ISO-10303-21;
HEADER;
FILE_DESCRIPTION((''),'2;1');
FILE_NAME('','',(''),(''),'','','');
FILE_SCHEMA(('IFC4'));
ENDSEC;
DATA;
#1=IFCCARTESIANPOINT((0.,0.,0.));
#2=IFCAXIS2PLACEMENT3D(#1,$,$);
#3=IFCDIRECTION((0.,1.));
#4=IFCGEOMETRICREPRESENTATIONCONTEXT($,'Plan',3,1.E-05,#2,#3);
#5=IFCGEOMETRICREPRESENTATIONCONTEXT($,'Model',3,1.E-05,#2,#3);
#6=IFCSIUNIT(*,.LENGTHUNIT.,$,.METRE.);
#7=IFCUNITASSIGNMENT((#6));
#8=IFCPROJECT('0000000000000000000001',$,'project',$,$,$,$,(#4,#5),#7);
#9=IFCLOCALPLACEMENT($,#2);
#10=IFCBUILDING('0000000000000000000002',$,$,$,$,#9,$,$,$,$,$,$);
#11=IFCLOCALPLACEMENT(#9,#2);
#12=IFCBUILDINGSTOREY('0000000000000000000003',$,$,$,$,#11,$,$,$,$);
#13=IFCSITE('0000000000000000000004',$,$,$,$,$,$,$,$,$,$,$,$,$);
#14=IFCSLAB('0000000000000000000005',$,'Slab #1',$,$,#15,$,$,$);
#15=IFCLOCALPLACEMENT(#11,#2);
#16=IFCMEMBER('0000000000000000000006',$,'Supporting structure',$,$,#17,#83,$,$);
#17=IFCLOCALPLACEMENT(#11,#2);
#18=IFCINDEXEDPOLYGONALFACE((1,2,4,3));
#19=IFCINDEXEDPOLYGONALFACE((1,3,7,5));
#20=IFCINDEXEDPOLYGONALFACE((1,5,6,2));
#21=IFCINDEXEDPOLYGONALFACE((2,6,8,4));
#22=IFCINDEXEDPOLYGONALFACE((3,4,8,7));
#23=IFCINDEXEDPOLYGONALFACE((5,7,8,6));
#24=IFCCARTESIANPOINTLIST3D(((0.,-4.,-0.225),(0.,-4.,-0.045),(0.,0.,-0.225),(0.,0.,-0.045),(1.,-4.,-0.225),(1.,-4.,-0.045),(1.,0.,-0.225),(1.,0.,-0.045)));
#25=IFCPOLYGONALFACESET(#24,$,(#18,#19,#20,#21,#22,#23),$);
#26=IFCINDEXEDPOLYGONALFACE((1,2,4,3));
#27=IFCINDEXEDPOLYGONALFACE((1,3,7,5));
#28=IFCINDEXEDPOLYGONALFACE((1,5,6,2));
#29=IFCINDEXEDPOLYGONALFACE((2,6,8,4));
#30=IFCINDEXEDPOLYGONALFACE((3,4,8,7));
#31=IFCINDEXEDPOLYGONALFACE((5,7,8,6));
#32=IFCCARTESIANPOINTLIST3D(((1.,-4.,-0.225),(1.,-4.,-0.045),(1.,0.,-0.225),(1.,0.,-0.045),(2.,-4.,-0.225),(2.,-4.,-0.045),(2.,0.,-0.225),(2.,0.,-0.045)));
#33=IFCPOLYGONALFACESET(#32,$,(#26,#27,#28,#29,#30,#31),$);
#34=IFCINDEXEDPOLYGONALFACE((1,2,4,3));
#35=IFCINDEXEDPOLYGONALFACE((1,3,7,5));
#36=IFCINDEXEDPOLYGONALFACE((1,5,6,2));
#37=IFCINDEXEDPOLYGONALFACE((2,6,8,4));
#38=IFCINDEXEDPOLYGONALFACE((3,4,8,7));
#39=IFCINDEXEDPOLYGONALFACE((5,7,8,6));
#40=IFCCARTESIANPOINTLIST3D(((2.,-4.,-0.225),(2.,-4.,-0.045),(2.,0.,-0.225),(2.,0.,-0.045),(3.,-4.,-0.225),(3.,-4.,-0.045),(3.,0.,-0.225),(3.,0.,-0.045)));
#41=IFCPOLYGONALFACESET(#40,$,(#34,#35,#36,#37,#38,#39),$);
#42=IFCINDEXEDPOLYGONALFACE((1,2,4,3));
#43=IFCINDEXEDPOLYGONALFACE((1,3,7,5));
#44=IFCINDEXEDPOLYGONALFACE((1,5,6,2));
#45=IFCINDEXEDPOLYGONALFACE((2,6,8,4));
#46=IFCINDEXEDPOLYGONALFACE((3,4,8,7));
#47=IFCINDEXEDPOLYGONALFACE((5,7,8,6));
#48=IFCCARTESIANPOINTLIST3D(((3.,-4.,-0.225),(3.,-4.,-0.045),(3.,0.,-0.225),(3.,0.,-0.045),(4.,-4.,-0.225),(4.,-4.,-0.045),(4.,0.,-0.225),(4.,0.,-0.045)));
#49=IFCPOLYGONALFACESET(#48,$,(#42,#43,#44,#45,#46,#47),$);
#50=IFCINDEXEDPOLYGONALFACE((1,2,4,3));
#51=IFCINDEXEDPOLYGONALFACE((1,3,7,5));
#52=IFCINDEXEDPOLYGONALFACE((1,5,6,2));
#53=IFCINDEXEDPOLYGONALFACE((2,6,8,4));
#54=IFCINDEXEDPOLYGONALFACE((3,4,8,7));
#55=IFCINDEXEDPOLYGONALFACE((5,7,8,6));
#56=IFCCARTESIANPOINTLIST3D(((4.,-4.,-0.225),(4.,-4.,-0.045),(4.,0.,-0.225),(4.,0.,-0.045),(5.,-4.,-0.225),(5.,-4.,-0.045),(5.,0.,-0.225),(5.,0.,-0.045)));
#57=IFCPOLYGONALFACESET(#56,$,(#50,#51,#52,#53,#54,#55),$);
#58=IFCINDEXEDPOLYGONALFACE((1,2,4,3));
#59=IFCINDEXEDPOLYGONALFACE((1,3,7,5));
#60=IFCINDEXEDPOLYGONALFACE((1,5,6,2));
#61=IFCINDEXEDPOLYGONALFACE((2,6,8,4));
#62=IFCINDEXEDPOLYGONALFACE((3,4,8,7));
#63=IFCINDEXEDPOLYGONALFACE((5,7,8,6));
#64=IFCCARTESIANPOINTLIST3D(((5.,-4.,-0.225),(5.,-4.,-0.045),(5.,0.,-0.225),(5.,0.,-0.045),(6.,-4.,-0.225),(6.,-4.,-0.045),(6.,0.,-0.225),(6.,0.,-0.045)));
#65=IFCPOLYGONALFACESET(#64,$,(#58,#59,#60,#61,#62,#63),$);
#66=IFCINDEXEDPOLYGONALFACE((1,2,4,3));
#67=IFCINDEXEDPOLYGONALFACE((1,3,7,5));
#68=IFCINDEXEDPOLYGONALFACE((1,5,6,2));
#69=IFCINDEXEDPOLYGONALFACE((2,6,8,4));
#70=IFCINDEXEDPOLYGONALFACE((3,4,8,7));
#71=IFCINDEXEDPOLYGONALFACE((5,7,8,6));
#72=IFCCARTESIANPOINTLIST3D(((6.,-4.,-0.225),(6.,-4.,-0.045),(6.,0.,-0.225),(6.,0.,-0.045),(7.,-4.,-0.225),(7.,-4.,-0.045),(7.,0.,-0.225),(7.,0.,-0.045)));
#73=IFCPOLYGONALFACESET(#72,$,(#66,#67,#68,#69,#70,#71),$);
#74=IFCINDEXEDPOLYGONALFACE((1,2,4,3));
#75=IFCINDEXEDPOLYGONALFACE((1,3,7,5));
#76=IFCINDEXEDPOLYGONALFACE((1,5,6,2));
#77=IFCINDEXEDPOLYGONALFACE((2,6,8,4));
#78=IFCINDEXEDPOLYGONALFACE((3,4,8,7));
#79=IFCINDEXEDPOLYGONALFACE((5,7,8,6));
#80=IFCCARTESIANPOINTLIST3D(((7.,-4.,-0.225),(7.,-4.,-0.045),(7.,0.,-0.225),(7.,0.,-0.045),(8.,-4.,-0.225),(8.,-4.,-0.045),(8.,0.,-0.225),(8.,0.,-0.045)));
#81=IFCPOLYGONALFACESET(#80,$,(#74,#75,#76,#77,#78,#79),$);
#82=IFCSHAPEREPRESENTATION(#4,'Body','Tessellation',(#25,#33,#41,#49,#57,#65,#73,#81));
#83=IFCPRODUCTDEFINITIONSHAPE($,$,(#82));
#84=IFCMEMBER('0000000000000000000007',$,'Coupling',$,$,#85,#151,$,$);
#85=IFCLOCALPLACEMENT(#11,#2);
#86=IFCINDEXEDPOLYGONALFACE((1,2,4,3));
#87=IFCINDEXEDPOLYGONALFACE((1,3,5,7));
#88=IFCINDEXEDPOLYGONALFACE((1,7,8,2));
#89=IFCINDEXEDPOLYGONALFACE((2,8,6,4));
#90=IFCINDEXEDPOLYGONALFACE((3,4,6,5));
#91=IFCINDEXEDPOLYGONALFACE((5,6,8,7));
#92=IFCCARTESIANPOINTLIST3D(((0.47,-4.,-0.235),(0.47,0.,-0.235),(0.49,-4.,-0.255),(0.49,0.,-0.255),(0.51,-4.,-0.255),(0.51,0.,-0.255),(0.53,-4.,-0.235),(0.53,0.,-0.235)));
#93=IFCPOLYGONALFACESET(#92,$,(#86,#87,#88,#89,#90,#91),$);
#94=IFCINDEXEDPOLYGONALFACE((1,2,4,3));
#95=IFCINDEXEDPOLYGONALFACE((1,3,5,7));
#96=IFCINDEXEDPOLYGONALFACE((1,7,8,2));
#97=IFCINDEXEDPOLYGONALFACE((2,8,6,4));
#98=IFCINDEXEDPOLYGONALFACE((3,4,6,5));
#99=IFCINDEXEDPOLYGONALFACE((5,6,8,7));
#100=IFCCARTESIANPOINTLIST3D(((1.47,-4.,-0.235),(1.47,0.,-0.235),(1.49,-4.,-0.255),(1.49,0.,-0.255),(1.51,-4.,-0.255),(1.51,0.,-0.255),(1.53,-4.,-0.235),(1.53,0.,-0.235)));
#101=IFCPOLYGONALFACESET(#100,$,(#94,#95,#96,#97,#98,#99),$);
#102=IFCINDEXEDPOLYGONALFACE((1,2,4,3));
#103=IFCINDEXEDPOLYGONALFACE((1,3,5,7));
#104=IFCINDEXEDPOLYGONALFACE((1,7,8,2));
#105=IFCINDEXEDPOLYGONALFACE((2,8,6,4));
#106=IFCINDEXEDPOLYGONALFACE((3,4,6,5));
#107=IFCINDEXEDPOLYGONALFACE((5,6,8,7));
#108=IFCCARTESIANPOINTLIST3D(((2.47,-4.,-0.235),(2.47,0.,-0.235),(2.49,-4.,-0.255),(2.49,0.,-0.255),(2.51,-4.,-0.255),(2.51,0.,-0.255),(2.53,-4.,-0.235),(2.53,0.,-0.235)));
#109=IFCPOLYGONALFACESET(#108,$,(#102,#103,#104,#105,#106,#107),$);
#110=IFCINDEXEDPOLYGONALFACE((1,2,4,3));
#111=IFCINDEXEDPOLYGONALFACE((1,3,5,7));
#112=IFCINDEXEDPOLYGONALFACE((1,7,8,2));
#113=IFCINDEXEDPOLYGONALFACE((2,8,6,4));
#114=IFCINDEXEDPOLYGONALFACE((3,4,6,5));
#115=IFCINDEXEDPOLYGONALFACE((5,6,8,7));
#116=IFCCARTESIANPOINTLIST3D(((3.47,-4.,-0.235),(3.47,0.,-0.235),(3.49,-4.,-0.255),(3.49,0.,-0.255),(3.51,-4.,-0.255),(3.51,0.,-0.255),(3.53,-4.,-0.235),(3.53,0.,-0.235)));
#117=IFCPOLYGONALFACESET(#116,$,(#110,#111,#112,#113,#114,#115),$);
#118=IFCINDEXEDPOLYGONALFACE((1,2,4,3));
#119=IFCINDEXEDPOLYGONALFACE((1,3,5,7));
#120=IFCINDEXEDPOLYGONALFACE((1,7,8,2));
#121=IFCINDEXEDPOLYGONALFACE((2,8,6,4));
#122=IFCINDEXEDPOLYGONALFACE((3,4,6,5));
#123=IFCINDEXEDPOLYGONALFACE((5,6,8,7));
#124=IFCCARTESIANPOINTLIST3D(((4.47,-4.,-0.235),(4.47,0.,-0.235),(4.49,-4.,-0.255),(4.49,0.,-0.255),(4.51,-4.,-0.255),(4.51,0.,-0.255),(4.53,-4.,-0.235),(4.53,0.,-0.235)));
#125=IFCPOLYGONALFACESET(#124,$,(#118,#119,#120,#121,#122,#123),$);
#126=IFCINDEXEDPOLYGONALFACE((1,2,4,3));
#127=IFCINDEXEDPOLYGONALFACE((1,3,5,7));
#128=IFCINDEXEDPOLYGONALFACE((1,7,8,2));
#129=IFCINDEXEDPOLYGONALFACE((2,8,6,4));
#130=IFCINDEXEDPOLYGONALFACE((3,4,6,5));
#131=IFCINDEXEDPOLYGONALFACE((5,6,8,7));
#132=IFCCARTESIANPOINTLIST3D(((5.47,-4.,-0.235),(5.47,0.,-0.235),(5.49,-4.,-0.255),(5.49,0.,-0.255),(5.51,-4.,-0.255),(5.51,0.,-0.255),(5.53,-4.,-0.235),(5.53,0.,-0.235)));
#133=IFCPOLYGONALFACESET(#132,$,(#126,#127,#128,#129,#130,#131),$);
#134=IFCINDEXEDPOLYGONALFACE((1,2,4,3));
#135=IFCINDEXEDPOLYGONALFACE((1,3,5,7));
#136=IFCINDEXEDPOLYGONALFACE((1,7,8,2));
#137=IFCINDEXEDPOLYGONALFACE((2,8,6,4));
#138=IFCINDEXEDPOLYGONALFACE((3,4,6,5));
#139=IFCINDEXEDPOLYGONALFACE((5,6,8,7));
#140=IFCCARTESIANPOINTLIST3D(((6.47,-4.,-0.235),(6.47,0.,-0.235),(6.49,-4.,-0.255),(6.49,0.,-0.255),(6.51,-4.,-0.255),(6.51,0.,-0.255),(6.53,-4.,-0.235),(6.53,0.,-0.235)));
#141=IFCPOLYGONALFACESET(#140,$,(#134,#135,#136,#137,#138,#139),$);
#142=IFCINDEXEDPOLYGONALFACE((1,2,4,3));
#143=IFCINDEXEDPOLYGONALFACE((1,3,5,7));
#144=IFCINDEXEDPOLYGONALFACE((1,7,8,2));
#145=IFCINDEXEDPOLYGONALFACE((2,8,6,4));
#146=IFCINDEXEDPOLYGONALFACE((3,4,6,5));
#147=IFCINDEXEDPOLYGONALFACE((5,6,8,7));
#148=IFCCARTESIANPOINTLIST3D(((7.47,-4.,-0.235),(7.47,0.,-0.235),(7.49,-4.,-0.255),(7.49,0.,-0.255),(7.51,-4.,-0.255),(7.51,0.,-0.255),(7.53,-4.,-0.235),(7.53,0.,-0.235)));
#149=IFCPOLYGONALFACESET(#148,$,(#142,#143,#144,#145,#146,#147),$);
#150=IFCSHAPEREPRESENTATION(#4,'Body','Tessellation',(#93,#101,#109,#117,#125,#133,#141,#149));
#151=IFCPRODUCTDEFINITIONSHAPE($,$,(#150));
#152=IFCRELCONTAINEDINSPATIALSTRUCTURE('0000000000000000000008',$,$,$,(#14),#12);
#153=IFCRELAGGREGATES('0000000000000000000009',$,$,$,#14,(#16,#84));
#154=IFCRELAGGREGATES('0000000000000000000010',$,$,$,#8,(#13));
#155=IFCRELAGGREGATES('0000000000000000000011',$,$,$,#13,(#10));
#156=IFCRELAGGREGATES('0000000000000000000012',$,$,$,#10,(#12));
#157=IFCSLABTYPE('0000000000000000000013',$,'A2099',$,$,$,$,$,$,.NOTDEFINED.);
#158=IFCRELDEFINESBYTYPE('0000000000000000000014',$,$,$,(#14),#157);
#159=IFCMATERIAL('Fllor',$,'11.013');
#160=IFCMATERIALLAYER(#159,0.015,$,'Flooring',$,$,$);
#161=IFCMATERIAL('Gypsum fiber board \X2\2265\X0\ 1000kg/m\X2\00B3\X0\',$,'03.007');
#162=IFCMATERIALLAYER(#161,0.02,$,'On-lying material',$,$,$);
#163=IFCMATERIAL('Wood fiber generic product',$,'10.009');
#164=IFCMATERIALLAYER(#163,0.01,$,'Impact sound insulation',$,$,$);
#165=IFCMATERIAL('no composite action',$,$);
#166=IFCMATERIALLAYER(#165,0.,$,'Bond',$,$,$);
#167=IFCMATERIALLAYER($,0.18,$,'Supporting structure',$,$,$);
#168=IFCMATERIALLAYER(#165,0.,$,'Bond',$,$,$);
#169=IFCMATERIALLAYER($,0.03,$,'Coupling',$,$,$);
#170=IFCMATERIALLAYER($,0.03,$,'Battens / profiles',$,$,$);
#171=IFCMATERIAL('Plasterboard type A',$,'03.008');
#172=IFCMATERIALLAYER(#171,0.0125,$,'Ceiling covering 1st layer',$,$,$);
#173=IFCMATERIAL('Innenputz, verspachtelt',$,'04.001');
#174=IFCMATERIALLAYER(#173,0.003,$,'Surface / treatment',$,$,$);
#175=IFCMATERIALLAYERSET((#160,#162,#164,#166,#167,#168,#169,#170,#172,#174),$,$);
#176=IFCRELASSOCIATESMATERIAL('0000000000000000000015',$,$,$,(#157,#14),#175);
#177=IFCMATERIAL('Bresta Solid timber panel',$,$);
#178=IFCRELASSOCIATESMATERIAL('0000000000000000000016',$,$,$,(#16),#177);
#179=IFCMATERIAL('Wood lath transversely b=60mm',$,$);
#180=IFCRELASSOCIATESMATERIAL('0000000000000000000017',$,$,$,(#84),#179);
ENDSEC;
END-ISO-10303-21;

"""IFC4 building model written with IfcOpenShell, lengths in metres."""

from ifc_helpers import new_model, si_unit, direction, frame, frame_2d, origin, place, context, project, spatial, polyline, rectangle, outline, extrude, material, layer, layer_set, type_object, element, aggregate, save


model = new_model("IFC4")

# Units and contexts
plan_context = context("Plan", 3, precision=1e-05, world=origin(), true_north=direction((0.0, 1.0)))
model_context = context("Model", 3, precision=1e-05, world=origin(), true_north=direction((0.0, 1.0)))
ifc_project = project(units=[si_unit("LENGTHUNIT", "METRE")], contexts=[plan_context, model_context])

# Site, building, storey
site = spatial("IfcSite", under=ifc_project)
building_placement = place(None, origin())
building = spatial("IfcBuilding", under=site, at=building_placement)
storey_placement = place(building_placement, origin())
storey = spatial("IfcBuildingStorey", under=building, at=storey_placement)

# Slab, members
ifc_material_1 = material(Name="Fllor", Category="11.013")
ifc_layer_1 = layer(ifc_material_1, 0.015, Name="Flooring")
ifc_material_2 = material(Name="Gypsum fiber board ≥ 1000kg/m³", Category="03.007")
ifc_layer_2 = layer(ifc_material_2, 0.02, Name="On-lying material")
ifc_material_3 = material(Name="Wood fiber generic product", Category="10.009")
ifc_layer_3 = layer(ifc_material_3, 0.01, Name="Impact sound insulation")
ifc_material_4 = material(Name="no composite action")
ifc_layer_4 = layer(ifc_material_4, 0.0, Name="Bond")
ifc_layer_5 = layer(None, 0.18, Name="Supporting structure")
ifc_layer_6 = layer(ifc_material_4, 0.0, Name="Bond")
ifc_layer_7 = layer(None, 0.03, Name="Coupling")
ifc_layer_8 = layer(None, 0.03, Name="Battens / profiles")
ifc_material_5 = material(Name="Plasterboard type A", Category="03.008")
ifc_layer_9 = layer(ifc_material_5, 0.0125, Name="Ceiling covering 1st layer")
ifc_material_6 = material(Name="Innenputz, verspachtelt", Category="04.001")
ifc_layer_10 = layer(ifc_material_6, 0.003, Name="Surface / treatment")
ifc_layer_set = layer_set([ifc_layer_1, ifc_layer_2, ifc_layer_3, ifc_layer_4, ifc_layer_5, ifc_layer_6, ifc_layer_7, ifc_layer_8, ifc_layer_9, ifc_layer_10])
slab_type = type_object("IfcSlabType", Name="A2099", PredefinedType="NOTDEFINED", material=ifc_layer_set)
slab_placement = place(None, frame((0.0, 0.0, 0.0), z_axis=(0.0, 0.0, -1.0), x_axis=(1.0, 0.0, 0.0)))
slab = element("IfcSlab", 1, at=slab_placement, inside=storey, type_object=slab_type, material=ifc_layer_set, Name="Slab #1")
ifc_material_7 = material(Name="Bresta Solid timber panel")
member_1_placement = place(slab_placement, origin())
member_1 = element("IfcMember", 2, at=member_1_placement, material=ifc_material_7, Name="Supporting structure", context=plan_context, shape_type="SweptSolid", body=[
    extrude(rectangle(XDim=1.0, YDim=0.18, at=frame_2d((0.5, 0.09), x_axis=(1.0, 0.0))), frame((0.0, 4.0, 0.045), z_axis=(0.0, -1.0, 0.0), x_axis=(1.0, 0.0, 0.0)), (0.0, 0.0, 1.0), 4.0),
    extrude(rectangle(XDim=1.0, YDim=0.18, at=frame_2d((0.5, 0.09), x_axis=(1.0, 0.0))), frame((1.0, 4.0, 0.045), z_axis=(0.0, -1.0, 0.0), x_axis=(1.0, 0.0, 0.0)), (0.0, 0.0, 1.0), 4.0),
    extrude(rectangle(XDim=1.0, YDim=0.18, at=frame_2d((0.5, 0.09), x_axis=(1.0, 0.0))), frame((2.0, 4.0, 0.045), z_axis=(0.0, -1.0, 0.0), x_axis=(1.0, 0.0, 0.0)), (0.0, 0.0, 1.0), 4.0),
    extrude(rectangle(XDim=1.0, YDim=0.18, at=frame_2d((0.5, 0.09), x_axis=(1.0, 0.0))), frame((3.0, 4.0, 0.045), z_axis=(0.0, -1.0, 0.0), x_axis=(1.0, 0.0, 0.0)), (0.0, 0.0, 1.0), 4.0),
    extrude(rectangle(XDim=1.0, YDim=0.18, at=frame_2d((0.5, 0.09), x_axis=(1.0, 0.0))), frame((4.0, 4.0, 0.045), z_axis=(0.0, -1.0, 0.0), x_axis=(1.0, 0.0, 0.0)), (0.0, 0.0, 1.0), 4.0),
    extrude(rectangle(XDim=1.0, YDim=0.18, at=frame_2d((0.5, 0.09), x_axis=(1.0, 0.0))), frame((5.0, 4.0, 0.045), z_axis=(0.0, -1.0, 0.0), x_axis=(1.0, 0.0, 0.0)), (0.0, 0.0, 1.0), 4.0),
    extrude(rectangle(XDim=1.0, YDim=0.18, at=frame_2d((0.5, 0.09), x_axis=(1.0, 0.0))), frame((6.0, 4.0, 0.045), z_axis=(0.0, -1.0, 0.0), x_axis=(1.0, 0.0, 0.0)), (0.0, 0.0, 1.0), 4.0),
    extrude(rectangle(XDim=1.0, YDim=0.18, at=frame_2d((0.5, 0.09), x_axis=(1.0, 0.0))), frame((7.0, 4.0, 0.045), z_axis=(0.0, -1.0, 0.0), x_axis=(1.0, 0.0, 0.0)), (0.0, 0.0, 1.0), 4.0),
])
ifc_material_8 = material(Name="Wood lath transversely b=60mm")
member_2_placement = place(slab_placement, origin())
member_2 = element("IfcMember", 3, at=member_2_placement, material=ifc_material_8, Name="Coupling", context=plan_context, shape_type="SweptSolid", body=[
    extrude(outline(polyline([(0.0, 0.0), (0.06, 0.0), (0.04, 0.02), (0.02, 0.02), (0.0, 0.0)])), frame((0.47, 4.0, 0.235), z_axis=(0.0, -1.0, 0.0), x_axis=(1.0, 0.0, 0.0)), (0.0, 0.0, 1.0), 4.0),
    extrude(outline(polyline([(0.0, 0.0), (0.06, 0.0), (0.04, 0.02), (0.02, 0.02), (0.0, 0.0)])), frame((1.47, 4.0, 0.235), z_axis=(0.0, -1.0, 0.0), x_axis=(1.0, 0.0, 0.0)), (0.0, 0.0, 1.0), 4.0),
    extrude(outline(polyline([(0.0, 0.0), (0.06, 0.0), (0.04, 0.02), (0.02, 0.02), (0.0, 0.0)])), frame((2.47, 4.0, 0.235), z_axis=(0.0, -1.0, 0.0), x_axis=(1.0, 0.0, 0.0)), (0.0, 0.0, 1.0), 4.0),
    extrude(outline(polyline([(0.0, 0.0), (0.06, 0.0), (0.04, 0.02), (0.02, 0.02), (0.0, 0.0)])), frame((3.47, 4.0, 0.235), z_axis=(0.0, -1.0, 0.0), x_axis=(1.0, 0.0, 0.0)), (0.0, 0.0, 1.0), 4.0),
    extrude(outline(polyline([(0.0, 0.0), (0.06, 0.0), (0.04, 0.02), (0.02, 0.02), (0.0, 0.0)])), frame((4.47, 4.0, 0.235), z_axis=(0.0, -1.0, 0.0), x_axis=(1.0, 0.0, 0.0)), (0.0, 0.0, 1.0), 4.0),
    extrude(outline(polyline([(0.0, 0.0), (0.06, 0.0), (0.04, 0.02), (0.02, 0.02), (0.0, 0.0)])), frame((5.47, 4.0, 0.235), z_axis=(0.0, -1.0, 0.0), x_axis=(1.0, 0.0, 0.0)), (0.0, 0.0, 1.0), 4.0),
    extrude(outline(polyline([(0.0, 0.0), (0.06, 0.0), (0.04, 0.02), (0.02, 0.02), (0.0, 0.0)])), frame((6.47, 4.0, 0.235), z_axis=(0.0, -1.0, 0.0), x_axis=(1.0, 0.0, 0.0)), (0.0, 0.0, 1.0), 4.0),
    extrude(outline(polyline([(0.0, 0.0), (0.06, 0.0), (0.04, 0.02), (0.02, 0.02), (0.0, 0.0)])), frame((7.47, 4.0, 0.235), z_axis=(0.0, -1.0, 0.0), x_axis=(1.0, 0.0, 0.0)), (0.0, 0.0, 1.0), 4.0),
])
aggregate(slab, [member_1, member_2])

save(model, "model.ifc")
